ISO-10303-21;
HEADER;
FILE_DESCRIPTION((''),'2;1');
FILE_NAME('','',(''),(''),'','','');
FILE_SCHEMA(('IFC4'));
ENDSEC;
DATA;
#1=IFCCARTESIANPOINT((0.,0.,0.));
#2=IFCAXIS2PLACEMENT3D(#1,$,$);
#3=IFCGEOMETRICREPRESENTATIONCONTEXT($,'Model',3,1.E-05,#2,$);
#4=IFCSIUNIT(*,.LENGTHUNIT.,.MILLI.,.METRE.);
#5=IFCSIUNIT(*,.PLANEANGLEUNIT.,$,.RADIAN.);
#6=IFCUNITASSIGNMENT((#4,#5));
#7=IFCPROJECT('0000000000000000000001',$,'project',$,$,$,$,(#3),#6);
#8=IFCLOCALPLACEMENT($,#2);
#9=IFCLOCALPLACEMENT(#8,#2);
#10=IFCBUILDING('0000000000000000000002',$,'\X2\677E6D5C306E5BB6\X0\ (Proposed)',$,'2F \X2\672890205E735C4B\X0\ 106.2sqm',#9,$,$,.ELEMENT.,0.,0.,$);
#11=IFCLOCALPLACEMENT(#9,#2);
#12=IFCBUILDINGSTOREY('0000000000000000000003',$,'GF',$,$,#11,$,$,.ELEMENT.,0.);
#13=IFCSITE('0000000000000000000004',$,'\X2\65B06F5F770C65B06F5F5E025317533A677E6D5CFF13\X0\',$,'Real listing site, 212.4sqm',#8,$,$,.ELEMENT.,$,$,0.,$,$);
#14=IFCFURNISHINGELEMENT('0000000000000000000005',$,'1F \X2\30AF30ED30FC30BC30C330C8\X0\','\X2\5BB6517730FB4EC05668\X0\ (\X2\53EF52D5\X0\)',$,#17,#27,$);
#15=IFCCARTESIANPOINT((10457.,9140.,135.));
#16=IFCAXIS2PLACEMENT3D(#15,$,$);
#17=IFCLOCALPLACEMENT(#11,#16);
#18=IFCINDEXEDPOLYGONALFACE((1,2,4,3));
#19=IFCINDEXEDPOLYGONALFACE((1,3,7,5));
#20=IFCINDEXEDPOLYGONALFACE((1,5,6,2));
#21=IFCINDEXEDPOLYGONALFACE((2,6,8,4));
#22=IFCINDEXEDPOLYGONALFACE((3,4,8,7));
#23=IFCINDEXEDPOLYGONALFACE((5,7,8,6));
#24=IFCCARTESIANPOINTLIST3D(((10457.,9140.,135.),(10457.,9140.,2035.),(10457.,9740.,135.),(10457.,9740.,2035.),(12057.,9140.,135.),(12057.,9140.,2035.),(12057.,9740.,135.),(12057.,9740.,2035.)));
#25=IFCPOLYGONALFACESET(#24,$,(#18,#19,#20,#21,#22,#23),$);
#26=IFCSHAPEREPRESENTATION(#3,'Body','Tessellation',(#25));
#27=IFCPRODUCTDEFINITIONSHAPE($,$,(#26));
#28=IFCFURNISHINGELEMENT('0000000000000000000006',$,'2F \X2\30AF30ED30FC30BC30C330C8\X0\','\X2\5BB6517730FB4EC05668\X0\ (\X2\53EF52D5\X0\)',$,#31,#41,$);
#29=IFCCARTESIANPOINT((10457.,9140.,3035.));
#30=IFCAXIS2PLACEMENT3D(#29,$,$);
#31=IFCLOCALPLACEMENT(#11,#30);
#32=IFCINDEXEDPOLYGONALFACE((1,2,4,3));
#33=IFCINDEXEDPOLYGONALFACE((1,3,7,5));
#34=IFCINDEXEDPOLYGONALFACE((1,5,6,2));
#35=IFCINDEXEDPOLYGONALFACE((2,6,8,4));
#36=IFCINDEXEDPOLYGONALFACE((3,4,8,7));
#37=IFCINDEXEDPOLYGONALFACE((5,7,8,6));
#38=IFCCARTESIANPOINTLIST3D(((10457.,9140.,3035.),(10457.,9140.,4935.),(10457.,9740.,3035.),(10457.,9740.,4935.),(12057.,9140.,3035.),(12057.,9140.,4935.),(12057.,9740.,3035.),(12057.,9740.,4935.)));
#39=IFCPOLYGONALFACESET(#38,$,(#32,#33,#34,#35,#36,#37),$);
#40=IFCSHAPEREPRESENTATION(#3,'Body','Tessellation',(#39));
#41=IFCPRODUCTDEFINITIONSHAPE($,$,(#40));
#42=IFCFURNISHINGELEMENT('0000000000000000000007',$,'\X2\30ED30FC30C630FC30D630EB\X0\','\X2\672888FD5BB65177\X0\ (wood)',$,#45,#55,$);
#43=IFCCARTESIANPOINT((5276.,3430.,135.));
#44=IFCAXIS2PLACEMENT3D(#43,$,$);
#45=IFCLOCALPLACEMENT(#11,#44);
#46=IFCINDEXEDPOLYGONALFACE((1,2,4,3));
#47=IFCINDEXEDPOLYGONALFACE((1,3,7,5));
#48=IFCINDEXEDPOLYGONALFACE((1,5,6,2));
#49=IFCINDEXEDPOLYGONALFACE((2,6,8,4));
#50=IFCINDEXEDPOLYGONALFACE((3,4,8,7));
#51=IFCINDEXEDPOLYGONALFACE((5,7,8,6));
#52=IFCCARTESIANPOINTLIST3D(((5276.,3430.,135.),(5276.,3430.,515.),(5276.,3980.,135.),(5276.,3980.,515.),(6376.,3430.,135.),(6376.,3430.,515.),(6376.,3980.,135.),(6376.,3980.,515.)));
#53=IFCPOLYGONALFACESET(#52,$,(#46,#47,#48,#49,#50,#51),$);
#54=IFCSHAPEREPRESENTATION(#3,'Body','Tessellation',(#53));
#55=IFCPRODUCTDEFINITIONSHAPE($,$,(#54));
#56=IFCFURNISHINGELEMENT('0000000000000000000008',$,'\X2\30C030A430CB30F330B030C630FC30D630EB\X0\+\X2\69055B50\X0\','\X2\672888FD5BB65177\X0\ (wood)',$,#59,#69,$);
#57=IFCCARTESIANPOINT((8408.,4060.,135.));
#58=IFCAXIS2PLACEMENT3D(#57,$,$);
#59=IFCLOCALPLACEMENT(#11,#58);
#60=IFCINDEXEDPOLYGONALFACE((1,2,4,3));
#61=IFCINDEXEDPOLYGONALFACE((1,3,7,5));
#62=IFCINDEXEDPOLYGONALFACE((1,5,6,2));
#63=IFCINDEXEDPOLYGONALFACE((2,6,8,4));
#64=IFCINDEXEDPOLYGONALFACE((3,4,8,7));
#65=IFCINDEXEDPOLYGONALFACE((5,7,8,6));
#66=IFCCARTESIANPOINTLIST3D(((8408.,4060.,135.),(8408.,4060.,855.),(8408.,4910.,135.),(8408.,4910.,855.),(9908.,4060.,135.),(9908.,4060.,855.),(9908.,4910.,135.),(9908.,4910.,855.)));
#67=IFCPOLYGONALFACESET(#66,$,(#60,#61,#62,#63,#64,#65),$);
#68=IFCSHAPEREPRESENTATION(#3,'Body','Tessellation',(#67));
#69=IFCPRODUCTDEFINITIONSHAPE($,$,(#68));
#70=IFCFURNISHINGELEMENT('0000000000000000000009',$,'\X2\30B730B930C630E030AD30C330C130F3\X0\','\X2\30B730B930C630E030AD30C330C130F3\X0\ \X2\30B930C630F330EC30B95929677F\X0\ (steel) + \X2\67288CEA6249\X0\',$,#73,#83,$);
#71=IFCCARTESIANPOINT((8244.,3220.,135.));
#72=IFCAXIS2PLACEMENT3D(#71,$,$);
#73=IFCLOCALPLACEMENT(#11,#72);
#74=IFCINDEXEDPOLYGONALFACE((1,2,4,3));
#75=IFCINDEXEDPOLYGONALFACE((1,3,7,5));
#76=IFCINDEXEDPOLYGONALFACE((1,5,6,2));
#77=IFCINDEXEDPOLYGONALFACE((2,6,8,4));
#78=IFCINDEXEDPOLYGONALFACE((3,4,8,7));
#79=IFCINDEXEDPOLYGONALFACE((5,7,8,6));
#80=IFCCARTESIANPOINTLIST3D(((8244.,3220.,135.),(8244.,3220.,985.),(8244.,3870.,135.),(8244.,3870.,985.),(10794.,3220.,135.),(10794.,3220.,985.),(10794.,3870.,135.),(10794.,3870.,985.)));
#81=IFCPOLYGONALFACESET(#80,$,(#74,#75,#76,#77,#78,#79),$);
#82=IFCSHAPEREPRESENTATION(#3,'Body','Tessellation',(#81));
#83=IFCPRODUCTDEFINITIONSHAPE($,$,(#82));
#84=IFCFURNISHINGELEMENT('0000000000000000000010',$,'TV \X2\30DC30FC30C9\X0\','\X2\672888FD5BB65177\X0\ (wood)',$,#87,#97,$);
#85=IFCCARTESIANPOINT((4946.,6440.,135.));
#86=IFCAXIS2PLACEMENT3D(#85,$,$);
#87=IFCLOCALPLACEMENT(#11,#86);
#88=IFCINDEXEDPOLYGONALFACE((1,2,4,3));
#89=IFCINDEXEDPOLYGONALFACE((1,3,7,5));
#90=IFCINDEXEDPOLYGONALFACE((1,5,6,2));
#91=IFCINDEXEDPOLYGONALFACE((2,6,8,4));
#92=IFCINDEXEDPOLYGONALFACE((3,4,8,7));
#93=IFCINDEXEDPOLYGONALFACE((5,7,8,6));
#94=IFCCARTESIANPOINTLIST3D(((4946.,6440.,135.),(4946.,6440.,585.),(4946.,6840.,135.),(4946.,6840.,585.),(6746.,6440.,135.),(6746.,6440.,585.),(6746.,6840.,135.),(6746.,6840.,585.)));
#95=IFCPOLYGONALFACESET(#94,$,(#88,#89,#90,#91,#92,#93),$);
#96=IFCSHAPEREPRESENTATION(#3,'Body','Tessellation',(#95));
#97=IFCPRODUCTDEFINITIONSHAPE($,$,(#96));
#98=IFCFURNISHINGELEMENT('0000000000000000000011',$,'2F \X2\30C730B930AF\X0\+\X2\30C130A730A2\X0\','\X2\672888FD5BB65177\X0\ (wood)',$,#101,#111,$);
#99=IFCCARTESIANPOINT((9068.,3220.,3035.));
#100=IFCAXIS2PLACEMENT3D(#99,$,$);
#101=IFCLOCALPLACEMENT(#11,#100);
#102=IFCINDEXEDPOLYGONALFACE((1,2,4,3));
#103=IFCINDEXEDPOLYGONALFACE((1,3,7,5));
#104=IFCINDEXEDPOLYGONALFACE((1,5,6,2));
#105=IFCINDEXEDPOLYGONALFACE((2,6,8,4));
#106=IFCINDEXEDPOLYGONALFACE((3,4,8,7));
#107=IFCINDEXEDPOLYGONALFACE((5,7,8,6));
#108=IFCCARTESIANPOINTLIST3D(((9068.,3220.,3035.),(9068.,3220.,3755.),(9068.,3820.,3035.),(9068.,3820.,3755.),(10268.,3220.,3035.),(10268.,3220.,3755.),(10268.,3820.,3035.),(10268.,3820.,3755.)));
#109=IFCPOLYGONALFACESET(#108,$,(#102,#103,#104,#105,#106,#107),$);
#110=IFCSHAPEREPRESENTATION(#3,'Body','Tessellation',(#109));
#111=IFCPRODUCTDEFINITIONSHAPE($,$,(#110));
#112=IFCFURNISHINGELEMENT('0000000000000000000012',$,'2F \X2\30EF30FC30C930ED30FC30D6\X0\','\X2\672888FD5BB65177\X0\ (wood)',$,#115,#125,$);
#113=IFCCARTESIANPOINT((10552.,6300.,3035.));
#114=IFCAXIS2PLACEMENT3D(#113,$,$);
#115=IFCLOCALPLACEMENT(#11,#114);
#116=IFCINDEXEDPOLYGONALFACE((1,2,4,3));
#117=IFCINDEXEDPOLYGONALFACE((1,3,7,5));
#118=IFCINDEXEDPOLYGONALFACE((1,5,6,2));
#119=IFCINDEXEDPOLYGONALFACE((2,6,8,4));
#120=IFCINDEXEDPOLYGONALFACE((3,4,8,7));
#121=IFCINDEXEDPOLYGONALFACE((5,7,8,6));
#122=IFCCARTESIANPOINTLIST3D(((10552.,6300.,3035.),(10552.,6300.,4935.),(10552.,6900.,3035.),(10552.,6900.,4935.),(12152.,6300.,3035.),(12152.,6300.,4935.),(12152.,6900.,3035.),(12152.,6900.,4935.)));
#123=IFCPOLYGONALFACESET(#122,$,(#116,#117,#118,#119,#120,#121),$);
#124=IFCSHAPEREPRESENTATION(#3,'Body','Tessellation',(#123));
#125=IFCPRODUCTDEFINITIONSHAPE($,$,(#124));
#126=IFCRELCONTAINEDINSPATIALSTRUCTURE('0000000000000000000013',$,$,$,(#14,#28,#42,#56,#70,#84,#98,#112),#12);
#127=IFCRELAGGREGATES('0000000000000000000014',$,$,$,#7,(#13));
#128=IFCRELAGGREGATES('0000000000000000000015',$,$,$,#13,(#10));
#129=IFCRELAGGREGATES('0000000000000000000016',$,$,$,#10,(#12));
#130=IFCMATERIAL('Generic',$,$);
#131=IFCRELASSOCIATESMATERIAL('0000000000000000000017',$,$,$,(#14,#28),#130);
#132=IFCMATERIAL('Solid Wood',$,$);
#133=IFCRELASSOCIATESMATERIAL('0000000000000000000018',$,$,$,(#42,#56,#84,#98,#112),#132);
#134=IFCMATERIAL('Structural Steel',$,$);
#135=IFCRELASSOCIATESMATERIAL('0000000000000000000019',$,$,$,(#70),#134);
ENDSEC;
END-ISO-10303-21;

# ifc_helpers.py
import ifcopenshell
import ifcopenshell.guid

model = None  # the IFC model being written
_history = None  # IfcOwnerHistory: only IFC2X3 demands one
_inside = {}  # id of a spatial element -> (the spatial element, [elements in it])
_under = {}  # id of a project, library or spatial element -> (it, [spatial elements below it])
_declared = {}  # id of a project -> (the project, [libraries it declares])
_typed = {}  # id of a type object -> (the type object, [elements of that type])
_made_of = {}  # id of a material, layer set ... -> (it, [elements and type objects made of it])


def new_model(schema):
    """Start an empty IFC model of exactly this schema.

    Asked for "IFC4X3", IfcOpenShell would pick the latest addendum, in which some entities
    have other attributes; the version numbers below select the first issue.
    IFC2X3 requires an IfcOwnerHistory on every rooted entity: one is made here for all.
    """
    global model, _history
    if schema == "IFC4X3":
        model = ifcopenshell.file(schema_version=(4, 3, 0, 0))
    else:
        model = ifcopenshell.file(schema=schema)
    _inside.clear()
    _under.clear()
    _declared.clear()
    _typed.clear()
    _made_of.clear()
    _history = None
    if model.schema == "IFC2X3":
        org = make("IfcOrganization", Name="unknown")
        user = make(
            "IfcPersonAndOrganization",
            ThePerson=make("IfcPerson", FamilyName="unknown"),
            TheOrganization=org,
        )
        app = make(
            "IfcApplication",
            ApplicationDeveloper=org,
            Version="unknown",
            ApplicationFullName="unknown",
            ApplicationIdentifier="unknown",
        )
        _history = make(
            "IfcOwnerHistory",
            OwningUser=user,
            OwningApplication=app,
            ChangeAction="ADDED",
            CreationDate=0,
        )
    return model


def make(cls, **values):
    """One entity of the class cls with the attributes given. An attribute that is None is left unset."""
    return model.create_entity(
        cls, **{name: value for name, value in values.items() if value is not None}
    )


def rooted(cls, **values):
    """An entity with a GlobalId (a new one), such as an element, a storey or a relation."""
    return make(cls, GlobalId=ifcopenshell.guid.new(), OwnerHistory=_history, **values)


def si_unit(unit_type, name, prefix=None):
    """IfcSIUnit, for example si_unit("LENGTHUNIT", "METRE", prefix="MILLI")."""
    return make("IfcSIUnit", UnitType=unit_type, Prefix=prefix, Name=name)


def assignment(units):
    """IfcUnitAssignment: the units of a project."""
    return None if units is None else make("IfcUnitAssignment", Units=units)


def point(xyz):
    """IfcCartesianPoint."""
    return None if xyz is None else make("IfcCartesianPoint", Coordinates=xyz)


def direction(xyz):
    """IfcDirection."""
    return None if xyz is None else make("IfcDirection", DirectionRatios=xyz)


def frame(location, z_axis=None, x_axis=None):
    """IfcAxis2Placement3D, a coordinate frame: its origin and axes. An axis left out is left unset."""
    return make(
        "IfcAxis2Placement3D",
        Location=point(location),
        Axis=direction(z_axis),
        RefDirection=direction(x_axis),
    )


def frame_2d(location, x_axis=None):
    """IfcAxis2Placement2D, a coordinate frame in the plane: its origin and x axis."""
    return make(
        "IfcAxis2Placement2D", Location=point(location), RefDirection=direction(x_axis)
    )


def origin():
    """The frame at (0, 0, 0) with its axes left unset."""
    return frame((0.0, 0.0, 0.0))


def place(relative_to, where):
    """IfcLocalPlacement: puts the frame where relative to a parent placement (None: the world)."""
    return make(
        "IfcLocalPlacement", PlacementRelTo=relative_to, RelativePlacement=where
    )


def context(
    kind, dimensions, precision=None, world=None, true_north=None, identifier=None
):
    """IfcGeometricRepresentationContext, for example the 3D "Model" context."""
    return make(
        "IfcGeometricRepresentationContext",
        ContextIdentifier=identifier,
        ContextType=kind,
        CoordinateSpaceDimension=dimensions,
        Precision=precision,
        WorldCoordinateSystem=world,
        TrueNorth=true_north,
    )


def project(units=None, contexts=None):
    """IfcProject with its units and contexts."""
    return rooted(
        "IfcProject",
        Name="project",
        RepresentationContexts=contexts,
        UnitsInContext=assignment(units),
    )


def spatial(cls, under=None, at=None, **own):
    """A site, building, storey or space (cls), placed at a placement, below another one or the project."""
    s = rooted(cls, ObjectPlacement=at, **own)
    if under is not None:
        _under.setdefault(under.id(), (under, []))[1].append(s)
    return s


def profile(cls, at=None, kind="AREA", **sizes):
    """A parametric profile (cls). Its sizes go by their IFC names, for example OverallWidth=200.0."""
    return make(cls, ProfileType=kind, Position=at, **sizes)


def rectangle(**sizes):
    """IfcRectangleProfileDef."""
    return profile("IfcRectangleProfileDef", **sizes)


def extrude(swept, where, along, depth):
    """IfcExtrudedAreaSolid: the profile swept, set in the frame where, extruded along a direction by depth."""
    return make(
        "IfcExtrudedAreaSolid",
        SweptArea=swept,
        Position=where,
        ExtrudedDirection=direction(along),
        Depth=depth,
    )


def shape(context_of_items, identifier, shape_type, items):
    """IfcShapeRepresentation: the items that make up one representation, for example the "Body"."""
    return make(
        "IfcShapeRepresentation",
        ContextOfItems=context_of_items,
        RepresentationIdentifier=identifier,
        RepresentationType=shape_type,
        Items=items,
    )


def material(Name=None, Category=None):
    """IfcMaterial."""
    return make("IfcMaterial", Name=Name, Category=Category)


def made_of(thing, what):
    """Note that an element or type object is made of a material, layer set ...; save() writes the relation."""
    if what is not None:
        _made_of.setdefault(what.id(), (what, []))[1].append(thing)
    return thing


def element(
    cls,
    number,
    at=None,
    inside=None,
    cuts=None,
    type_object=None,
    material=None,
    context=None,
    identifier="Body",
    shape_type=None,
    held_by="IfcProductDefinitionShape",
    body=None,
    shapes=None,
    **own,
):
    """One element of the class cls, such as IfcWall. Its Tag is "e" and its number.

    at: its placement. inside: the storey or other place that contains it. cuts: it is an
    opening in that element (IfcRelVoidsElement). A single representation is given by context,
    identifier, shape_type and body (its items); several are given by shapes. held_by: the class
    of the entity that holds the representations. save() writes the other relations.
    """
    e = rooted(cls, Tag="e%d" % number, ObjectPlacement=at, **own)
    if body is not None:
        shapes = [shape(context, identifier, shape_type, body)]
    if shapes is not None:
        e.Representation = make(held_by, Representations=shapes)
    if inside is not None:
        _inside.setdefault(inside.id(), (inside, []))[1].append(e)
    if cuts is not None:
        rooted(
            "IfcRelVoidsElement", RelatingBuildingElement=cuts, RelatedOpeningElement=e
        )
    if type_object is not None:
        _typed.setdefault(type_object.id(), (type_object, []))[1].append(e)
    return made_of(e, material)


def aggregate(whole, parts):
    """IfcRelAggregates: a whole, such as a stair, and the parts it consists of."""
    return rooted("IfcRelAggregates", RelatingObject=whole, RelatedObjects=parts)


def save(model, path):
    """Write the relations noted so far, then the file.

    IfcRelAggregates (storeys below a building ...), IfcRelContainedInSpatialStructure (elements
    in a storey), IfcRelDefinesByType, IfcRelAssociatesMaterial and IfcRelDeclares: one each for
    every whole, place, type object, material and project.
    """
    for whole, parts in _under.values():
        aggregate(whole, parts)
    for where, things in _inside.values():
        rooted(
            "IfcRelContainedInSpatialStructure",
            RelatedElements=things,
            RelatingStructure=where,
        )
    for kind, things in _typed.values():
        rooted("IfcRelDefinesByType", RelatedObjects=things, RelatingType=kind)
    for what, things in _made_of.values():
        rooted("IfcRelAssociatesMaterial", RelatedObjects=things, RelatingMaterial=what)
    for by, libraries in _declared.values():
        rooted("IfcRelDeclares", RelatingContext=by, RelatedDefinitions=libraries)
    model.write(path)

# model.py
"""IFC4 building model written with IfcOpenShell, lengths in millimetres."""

from ifc_helpers import new_model, si_unit, frame, frame_2d, origin, place, context, project, spatial, rectangle, extrude, material, element, save


model = new_model("IFC4")

# Units and contexts
model_context = context("Model", 3, precision=1e-05, world=origin())
ifc_project = project(units=[si_unit("LENGTHUNIT", "METRE", prefix="MILLI"), si_unit("PLANEANGLEUNIT", "RADIAN")], contexts=[model_context])

# Site, building, storey
site_placement = place(None, origin())
site = spatial("IfcSite", under=ifc_project, at=site_placement, Name="新潟県新潟市北区松浜３", ObjectType="Real listing site, 212.4sqm", CompositionType="ELEMENT", RefElevation=0.0)
building_placement = place(site_placement, origin())
building = spatial("IfcBuilding", under=site, at=building_placement, Name="松浜の家 (Proposed)", ObjectType="2F 木造平屋 106.2sqm", CompositionType="ELEMENT", ElevationOfRefHeight=0.0, ElevationOfTerrain=0.0)
storey_placement = place(building_placement, origin())
storey = spatial("IfcBuildingStorey", under=building, at=storey_placement, Name="GF", CompositionType="ELEMENT", Elevation=0.0)

# Shared definitions
ifc_material_1 = material(Name="Solid Wood")

# Shared definitions
ifc_material_2 = material(Name="Generic")

# Furnishing elements
furnishing_1_placement = place(storey_placement, frame((10457.0, 9140.0, 135.0)))
element("IfcFurnishingElement", 1, at=furnishing_1_placement, inside=storey, material=ifc_material_2, Name="1F クローゼット", Description="家具・什器 (可動)", context=model_context, shape_type="SweptSolid", body=[
    extrude(rectangle(XDim=1600.0, YDim=600.0, at=frame_2d((800.0, 300.0))), frame((10457.0, 9140.0, 135.0)), (0.0, 0.0, 1.0), 1900.0),
])
furnishing_2_placement = place(storey_placement, frame((10457.0, 9140.0, 3035.0)))
element("IfcFurnishingElement", 2, at=furnishing_2_placement, inside=storey, material=ifc_material_2, Name="2F クローゼット", Description="家具・什器 (可動)", context=model_context, shape_type="SweptSolid", body=[
    extrude(rectangle(XDim=1600.0, YDim=600.0, at=frame_2d((800.0, 300.0))), frame((10457.0, 9140.0, 3035.0)), (0.0, 0.0, 1.0), 1900.0),
])
furnishing_3_placement = place(storey_placement, frame((5276.0, 3430.0, 135.0)))
element("IfcFurnishingElement", 3, at=furnishing_3_placement, inside=storey, material=ifc_material_1, Name="ローテーブル", Description="木製家具 (wood)", context=model_context, shape_type="SweptSolid", body=[
    extrude(rectangle(XDim=1100.0, YDim=550.0, at=frame_2d((550.0, 275.0))), frame((5276.0, 3430.0, 135.0)), (0.0, 0.0, 1.0), 380.0),
])
furnishing_4_placement = place(storey_placement, frame((8408.0, 4060.0, 135.0)))
element("IfcFurnishingElement", 4, at=furnishing_4_placement, inside=storey, material=ifc_material_1, Name="ダイニングテーブル+椅子", Description="木製家具 (wood)", context=model_context, shape_type="SweptSolid", body=[
    extrude(rectangle(XDim=1500.0, YDim=850.0, at=frame_2d((750.0, 425.0))), frame((8408.0, 4060.0, 135.0)), (0.0, 0.0, 1.0), 720.0),
])
ifc_material_3 = material(Name="Structural Steel")
furnishing_5_placement = place(storey_placement, frame((8244.0, 3220.0, 135.0)))
element("IfcFurnishingElement", 5, at=furnishing_5_placement, inside=storey, material=ifc_material_3, Name="システムキッチン", Description="システムキッチン ステンレス天板 (steel) + 木質扉", context=model_context, shape_type="SweptSolid", body=[
    extrude(rectangle(XDim=2550.0, YDim=650.0, at=frame_2d((1275.0, 325.0))), frame((8244.0, 3220.0, 135.0)), (0.0, 0.0, 1.0), 850.0),
])
furnishing_6_placement = place(storey_placement, frame((4946.0, 6440.0, 135.0)))
element("IfcFurnishingElement", 6, at=furnishing_6_placement, inside=storey, material=ifc_material_1, Name="TV ボード", Description="木製家具 (wood)", context=model_context, shape_type="SweptSolid", body=[
    extrude(rectangle(XDim=1800.0, YDim=400.0, at=frame_2d((900.0, 200.0))), frame((4946.0, 6440.0, 135.0)), (0.0, 0.0, 1.0), 450.0),
])
furnishing_7_placement = place(storey_placement, frame((9068.0, 3220.0, 3035.0)))
element("IfcFurnishingElement", 7, at=furnishing_7_placement, inside=storey, material=ifc_material_1, Name="2F デスク+チェア", Description="木製家具 (wood)", context=model_context, shape_type="SweptSolid", body=[
    extrude(rectangle(XDim=1200.0, YDim=600.0, at=frame_2d((600.0, 300.0))), frame((9068.0, 3220.0, 3035.0)), (0.0, 0.0, 1.0), 720.0),
])
furnishing_8_placement = place(storey_placement, frame((10552.0, 6300.0, 3035.0)))
element("IfcFurnishingElement", 8, at=furnishing_8_placement, inside=storey, material=ifc_material_1, Name="2F ワードローブ", Description="木製家具 (wood)", context=model_context, shape_type="SweptSolid", body=[
    extrude(rectangle(XDim=1600.0, YDim=600.0, at=frame_2d((800.0, 300.0))), frame((10552.0, 6300.0, 3035.0)), (0.0, 0.0, 1.0), 1900.0),
])

save(model, "model.ifc")
